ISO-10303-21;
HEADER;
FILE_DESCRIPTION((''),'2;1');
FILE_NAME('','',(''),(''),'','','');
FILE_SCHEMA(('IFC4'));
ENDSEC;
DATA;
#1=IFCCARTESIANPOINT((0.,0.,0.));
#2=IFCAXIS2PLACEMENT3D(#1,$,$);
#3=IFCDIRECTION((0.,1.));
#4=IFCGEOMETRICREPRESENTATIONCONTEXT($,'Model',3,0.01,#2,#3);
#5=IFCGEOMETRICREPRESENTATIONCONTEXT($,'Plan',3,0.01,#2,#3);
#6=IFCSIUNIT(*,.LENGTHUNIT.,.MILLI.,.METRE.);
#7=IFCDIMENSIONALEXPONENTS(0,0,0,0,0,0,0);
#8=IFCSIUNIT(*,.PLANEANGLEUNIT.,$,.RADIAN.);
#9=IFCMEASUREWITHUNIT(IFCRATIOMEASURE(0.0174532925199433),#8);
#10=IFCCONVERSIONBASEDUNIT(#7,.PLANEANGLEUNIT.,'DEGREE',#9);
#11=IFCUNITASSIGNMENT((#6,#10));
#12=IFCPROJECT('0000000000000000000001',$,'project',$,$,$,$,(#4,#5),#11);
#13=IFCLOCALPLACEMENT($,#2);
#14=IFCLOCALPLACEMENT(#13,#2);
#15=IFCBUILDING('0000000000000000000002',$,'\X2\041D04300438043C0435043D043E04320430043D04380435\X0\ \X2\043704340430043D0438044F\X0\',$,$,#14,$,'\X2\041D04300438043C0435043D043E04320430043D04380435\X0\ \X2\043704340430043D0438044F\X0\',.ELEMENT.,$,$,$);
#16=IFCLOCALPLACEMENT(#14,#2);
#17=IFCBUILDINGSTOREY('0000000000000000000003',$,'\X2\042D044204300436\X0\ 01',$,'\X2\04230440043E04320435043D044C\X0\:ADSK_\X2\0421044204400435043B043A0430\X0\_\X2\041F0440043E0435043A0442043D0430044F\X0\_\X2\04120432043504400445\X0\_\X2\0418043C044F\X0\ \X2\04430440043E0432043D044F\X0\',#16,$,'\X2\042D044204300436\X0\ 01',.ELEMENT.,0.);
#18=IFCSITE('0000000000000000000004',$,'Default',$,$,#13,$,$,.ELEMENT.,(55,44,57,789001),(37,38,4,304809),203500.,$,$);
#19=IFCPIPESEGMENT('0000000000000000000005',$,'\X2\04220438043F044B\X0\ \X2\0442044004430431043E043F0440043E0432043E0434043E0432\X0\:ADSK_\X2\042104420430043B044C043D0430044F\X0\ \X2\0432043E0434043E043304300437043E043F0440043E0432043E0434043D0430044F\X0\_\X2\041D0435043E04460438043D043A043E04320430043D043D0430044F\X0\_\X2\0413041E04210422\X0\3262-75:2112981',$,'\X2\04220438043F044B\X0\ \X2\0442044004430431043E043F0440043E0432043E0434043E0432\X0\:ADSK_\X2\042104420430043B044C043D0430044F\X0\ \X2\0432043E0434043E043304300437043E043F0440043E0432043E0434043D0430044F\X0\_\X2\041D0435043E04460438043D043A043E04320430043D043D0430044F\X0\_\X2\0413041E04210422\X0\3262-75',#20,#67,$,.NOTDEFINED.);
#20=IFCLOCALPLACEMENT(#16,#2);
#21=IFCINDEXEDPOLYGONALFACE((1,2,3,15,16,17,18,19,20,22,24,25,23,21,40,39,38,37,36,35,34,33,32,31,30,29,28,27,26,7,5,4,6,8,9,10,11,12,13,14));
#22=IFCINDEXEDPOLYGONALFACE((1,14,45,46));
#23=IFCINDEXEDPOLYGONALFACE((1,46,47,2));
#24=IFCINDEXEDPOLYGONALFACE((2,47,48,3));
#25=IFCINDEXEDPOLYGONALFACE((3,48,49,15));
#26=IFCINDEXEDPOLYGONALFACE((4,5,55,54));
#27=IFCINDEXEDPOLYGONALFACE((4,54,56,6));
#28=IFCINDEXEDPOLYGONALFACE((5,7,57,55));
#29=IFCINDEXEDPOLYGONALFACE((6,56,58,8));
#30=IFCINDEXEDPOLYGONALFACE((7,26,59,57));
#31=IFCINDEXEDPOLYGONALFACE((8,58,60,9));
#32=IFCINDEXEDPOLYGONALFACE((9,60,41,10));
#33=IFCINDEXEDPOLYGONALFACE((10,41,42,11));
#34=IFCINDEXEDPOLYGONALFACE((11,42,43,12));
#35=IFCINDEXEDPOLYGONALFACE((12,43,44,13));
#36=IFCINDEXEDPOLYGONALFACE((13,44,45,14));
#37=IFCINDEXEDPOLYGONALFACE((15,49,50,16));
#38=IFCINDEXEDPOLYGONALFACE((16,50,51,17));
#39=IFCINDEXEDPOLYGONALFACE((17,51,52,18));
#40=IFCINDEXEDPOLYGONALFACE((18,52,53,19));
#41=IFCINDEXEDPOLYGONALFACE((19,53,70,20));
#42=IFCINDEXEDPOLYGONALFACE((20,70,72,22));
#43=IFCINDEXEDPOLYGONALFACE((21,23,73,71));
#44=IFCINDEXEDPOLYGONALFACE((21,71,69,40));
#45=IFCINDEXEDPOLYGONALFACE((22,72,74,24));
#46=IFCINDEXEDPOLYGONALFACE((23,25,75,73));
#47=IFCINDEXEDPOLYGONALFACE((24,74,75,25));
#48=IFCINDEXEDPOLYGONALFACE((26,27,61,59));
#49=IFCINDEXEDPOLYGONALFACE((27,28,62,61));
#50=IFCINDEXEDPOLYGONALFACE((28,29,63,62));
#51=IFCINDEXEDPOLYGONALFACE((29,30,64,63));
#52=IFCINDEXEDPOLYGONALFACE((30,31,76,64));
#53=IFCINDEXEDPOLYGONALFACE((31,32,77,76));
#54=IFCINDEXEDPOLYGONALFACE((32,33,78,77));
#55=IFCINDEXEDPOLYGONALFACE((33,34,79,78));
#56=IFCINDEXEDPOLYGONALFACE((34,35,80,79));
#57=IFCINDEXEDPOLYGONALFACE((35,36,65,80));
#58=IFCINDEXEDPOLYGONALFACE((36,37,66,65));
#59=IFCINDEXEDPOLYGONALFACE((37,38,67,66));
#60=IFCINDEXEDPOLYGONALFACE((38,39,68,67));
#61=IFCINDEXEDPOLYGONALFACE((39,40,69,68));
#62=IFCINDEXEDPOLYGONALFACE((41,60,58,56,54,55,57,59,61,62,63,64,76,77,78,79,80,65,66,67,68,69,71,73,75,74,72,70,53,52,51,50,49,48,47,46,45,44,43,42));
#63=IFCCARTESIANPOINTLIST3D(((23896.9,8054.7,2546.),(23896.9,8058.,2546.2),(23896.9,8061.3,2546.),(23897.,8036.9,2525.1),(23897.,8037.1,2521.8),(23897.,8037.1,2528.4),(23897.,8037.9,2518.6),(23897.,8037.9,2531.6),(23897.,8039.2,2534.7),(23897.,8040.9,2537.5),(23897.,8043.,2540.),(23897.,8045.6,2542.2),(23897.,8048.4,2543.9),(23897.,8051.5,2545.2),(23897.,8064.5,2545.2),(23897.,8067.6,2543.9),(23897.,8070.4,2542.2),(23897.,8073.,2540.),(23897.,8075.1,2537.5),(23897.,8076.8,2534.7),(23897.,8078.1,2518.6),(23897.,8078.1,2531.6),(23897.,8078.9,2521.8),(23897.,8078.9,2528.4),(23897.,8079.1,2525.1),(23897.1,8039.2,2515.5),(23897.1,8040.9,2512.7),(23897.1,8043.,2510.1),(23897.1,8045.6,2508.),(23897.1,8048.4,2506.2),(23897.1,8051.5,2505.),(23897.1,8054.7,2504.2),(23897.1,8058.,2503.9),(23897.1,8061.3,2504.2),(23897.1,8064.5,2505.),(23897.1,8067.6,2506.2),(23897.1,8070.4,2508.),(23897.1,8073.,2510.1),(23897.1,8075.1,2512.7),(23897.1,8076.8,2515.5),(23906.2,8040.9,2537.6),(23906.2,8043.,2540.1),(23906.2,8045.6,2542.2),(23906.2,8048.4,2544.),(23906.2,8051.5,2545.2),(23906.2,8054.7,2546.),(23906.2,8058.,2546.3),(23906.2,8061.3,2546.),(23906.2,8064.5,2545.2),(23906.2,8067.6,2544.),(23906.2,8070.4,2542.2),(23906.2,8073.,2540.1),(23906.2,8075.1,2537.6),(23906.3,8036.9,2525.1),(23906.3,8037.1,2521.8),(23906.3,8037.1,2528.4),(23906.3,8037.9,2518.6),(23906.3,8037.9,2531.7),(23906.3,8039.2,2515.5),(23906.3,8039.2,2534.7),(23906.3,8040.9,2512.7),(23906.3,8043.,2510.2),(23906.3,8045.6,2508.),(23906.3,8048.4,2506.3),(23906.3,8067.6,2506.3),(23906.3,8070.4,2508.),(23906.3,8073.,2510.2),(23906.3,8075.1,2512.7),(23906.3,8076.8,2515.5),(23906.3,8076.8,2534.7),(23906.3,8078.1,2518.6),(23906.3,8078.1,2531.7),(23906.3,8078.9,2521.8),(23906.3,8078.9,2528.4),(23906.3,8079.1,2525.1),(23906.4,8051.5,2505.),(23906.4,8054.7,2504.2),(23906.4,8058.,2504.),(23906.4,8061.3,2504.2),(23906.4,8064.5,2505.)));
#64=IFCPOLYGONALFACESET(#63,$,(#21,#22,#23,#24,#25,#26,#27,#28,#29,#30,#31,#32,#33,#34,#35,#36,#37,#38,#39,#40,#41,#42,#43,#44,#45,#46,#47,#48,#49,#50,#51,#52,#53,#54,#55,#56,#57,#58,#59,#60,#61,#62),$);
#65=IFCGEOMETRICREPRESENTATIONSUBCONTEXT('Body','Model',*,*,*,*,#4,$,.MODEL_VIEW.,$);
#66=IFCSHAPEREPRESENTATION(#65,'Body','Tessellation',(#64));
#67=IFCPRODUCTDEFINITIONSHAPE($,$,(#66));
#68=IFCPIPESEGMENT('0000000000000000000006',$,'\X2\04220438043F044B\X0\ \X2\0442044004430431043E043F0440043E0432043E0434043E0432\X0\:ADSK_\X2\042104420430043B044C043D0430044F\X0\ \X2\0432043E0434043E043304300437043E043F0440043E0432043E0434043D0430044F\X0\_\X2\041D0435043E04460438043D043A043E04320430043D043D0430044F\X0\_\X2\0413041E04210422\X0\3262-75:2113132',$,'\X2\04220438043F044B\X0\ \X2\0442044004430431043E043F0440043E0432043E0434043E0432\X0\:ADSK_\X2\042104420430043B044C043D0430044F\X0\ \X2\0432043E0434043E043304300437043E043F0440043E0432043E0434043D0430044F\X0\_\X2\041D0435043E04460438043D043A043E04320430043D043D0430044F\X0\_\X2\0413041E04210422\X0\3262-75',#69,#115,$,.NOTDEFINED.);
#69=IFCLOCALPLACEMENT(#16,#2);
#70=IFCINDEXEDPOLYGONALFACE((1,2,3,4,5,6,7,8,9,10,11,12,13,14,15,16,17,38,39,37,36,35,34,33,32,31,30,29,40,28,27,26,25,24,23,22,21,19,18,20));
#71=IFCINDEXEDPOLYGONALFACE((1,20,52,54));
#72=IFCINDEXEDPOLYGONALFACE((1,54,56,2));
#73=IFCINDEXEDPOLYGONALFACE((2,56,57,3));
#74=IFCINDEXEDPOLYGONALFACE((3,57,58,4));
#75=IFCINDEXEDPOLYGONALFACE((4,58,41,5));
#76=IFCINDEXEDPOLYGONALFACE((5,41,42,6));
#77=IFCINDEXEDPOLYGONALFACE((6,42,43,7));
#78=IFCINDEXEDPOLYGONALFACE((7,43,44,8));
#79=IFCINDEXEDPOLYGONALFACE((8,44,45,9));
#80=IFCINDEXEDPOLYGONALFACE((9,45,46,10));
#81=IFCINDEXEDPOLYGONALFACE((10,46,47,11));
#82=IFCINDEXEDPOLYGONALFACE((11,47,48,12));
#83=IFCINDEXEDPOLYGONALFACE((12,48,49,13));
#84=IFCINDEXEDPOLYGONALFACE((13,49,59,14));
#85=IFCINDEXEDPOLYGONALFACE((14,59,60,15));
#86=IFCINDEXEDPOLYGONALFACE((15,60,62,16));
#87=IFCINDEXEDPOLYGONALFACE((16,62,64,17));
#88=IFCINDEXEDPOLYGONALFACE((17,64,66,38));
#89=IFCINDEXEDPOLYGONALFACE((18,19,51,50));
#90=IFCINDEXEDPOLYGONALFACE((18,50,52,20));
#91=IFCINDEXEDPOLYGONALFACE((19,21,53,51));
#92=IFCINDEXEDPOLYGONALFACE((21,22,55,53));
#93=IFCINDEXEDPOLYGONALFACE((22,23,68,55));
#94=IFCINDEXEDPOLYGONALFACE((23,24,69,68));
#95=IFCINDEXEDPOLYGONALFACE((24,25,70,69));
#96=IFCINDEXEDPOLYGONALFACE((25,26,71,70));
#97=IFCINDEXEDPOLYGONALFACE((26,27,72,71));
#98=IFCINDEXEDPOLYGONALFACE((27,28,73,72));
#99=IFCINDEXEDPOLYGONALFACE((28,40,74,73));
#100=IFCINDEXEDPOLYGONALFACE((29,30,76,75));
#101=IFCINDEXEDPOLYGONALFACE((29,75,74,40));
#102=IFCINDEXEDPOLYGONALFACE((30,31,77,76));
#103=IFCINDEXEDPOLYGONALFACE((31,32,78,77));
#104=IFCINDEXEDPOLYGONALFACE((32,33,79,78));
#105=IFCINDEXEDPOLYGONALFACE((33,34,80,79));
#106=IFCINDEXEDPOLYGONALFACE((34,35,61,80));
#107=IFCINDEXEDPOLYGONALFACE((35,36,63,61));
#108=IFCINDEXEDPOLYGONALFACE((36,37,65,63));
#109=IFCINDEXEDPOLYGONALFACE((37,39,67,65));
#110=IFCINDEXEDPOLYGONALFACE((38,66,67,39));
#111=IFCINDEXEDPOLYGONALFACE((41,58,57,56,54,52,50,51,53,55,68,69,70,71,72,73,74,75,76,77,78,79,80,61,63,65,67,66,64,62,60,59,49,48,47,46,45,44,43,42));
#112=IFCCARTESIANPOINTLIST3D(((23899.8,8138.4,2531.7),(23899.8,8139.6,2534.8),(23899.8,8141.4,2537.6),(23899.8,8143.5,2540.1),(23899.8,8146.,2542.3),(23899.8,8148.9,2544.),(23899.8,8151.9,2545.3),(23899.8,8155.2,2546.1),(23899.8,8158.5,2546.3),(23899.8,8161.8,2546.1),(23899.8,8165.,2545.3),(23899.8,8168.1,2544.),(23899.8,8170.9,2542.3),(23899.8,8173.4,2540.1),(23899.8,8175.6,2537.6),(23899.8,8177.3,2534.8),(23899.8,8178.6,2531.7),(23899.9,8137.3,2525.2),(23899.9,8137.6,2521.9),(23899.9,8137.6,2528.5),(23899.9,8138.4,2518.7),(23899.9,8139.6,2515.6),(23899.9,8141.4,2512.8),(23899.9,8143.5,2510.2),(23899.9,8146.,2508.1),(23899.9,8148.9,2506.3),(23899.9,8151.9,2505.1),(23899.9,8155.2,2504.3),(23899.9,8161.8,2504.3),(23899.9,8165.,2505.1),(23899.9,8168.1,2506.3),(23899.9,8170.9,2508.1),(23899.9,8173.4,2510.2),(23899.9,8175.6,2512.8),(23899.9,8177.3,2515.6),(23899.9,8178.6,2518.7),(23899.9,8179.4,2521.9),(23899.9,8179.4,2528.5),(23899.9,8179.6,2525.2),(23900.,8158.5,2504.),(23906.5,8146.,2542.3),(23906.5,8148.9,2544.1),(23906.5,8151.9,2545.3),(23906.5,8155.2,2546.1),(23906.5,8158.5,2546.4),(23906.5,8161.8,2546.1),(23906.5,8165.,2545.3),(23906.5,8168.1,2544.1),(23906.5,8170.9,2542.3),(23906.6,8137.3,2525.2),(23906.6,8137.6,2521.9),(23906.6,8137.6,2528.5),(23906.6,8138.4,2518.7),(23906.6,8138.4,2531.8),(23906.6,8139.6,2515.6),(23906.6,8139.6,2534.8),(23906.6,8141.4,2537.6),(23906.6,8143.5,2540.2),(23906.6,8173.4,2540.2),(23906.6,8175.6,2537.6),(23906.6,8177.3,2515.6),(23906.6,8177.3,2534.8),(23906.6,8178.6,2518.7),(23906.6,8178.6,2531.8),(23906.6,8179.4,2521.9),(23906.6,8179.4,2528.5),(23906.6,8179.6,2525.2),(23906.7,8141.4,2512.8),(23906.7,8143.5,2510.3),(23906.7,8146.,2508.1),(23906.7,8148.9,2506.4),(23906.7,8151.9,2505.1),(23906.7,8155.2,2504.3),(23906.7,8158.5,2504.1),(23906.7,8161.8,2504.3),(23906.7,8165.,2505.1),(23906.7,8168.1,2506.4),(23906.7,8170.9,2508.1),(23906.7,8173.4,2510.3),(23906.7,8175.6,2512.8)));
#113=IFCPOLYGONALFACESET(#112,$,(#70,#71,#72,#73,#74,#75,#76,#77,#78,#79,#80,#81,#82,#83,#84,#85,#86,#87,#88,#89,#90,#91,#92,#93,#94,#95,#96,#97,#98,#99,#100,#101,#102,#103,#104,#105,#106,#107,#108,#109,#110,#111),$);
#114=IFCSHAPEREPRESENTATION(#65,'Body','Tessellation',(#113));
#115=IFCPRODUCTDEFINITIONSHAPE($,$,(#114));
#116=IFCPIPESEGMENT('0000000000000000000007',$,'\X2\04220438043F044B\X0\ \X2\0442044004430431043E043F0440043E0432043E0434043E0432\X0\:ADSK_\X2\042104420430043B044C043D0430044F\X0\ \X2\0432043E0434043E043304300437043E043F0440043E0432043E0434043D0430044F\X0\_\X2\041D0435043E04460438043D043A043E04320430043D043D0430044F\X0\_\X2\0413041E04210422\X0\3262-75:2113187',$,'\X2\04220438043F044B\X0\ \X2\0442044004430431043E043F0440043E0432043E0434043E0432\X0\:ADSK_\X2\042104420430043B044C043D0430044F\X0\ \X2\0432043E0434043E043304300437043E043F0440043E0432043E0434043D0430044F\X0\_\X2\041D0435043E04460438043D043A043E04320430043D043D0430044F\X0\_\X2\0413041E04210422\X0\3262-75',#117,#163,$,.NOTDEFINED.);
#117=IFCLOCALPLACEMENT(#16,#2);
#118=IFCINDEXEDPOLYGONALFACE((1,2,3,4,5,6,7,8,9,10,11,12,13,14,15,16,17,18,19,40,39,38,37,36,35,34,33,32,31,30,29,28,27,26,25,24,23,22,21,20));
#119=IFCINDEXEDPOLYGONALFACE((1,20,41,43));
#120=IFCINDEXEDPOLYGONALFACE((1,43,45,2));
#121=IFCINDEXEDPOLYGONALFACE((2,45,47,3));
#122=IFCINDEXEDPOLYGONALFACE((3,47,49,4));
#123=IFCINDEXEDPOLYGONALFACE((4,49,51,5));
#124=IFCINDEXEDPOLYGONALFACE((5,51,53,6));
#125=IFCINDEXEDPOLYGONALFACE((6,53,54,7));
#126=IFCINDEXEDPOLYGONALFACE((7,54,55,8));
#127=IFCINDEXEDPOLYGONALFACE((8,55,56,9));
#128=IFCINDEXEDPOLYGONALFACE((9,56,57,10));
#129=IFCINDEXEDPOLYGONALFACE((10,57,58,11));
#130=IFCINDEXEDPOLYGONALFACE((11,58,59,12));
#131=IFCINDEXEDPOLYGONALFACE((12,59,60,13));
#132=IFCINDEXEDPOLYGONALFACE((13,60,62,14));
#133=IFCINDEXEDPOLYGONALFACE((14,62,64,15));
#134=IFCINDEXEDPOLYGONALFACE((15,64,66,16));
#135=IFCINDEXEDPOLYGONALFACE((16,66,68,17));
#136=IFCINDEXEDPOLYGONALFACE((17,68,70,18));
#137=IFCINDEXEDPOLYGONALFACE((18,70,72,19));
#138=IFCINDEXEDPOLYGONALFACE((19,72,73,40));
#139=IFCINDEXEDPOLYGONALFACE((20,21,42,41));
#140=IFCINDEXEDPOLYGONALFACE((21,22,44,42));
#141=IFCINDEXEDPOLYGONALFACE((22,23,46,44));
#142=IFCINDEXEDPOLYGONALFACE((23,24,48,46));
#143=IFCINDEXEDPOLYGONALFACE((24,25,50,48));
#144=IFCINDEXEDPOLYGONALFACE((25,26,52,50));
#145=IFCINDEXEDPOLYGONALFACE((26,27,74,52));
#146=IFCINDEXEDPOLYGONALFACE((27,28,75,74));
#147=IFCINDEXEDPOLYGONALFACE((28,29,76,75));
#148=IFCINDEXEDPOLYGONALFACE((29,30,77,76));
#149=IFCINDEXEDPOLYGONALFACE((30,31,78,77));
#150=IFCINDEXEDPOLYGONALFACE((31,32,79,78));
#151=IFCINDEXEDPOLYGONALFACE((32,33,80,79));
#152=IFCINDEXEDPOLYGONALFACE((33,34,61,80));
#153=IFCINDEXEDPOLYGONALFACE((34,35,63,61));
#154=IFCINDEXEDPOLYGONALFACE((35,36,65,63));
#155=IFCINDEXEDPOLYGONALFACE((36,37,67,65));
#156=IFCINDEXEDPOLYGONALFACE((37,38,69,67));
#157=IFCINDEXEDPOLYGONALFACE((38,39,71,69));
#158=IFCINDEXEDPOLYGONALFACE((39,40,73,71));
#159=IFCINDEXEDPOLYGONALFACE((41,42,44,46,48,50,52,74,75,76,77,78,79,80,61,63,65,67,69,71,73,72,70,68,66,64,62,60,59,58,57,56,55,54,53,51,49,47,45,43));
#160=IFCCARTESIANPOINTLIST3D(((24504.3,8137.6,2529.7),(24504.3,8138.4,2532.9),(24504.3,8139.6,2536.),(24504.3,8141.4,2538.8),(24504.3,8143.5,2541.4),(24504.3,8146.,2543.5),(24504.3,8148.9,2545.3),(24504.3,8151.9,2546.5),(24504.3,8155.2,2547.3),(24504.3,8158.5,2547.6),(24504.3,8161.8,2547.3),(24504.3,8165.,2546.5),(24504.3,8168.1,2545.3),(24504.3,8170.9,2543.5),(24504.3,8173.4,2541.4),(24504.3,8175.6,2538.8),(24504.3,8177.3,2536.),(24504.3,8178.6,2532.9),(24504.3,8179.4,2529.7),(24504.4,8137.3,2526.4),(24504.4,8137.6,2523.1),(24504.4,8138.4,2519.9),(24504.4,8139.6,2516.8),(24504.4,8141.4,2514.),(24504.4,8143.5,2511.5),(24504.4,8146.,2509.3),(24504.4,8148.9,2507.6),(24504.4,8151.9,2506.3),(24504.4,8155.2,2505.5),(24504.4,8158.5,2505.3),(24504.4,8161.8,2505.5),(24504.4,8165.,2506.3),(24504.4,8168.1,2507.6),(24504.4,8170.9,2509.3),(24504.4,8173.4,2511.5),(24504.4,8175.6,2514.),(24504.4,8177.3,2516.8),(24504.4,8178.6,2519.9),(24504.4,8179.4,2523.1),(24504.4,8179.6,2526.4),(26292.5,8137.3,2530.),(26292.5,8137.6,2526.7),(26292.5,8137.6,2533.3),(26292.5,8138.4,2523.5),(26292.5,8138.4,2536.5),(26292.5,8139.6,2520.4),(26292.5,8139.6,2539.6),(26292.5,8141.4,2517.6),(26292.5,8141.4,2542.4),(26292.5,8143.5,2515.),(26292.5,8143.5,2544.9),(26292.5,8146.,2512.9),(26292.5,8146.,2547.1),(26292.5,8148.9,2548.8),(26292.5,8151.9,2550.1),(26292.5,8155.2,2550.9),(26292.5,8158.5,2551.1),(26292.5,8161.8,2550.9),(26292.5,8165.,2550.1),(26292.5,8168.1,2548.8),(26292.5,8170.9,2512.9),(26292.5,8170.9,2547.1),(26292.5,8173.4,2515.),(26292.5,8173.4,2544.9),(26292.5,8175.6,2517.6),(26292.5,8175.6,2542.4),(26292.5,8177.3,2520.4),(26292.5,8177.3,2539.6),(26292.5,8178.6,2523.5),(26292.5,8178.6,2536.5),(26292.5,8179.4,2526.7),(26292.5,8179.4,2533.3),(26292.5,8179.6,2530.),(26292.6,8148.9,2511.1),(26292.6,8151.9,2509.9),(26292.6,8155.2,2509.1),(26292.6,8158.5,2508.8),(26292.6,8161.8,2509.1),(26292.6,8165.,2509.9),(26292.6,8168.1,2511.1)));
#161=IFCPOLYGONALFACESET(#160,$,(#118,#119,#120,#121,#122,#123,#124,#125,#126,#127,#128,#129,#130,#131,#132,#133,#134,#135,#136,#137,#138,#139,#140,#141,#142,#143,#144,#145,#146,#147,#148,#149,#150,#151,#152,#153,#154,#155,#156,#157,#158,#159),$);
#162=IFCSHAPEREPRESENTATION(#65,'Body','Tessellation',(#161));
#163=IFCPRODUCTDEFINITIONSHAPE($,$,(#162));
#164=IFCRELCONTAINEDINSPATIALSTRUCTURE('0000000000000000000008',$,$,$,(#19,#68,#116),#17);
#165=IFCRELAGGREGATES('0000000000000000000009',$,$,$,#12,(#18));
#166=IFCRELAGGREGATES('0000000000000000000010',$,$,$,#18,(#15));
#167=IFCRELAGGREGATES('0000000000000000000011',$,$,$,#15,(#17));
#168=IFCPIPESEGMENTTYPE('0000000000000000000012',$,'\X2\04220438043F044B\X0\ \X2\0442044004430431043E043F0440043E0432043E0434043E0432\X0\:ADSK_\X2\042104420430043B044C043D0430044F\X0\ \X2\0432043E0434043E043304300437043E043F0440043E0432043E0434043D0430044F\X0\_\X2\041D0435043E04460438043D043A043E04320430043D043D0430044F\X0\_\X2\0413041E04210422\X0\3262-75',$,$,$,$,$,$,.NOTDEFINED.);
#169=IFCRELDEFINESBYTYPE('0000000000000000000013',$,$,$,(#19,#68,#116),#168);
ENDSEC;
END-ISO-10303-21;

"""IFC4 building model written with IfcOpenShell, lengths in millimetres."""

from ifc_helpers import new_model, entity, si_unit, converted_unit, direction, frame, origin, place, context, subcontext, project, spatial, indexed_curve, outline, extrude, type_object, element, save


model = new_model("IFC4")

# Units and contexts
model_context = context("Model", 3, precision=0.01, world=origin(), true_north=direction((0.0, 1.0)))
plan_context = context("Plan", 3, precision=0.01, world=origin(), true_north=direction((0.0, 1.0)))
body_context = subcontext(model_context, "Body", "Model", "MODEL_VIEW")
ifc_project = project(units=[si_unit("LENGTHUNIT", "METRE", prefix="MILLI"), converted_unit("PLANEANGLEUNIT", "DEGREE", entity("IfcRatioMeasure", 0.0174532925199433), si_unit("PLANEANGLEUNIT", "RADIAN"), dimensions=[0, 0, 0, 0, 0, 0, 0])], contexts=[model_context, plan_context])

# Site, building, storey
site_placement = place(None, origin())
site = spatial("IfcSite", under=ifc_project, at=site_placement, Name="Default", CompositionType="ELEMENT", RefLatitude=(55, 44, 57, 789001), RefLongitude=(37, 38, 4, 304809), RefElevation=203500.0)
building_placement = place(site_placement, origin())
building = spatial("IfcBuilding", under=site, at=building_placement, Name="Наименование здания", LongName="Наименование здания", CompositionType="ELEMENT")
storey_placement = place(building_placement, origin())
storey = spatial("IfcBuildingStorey", under=building, at=storey_placement, Name="Этаж 01", ObjectType="Уровень:ADSK_Стрелка_Проектная_Вверх_Имя уровня", LongName="Этаж 01", CompositionType="ELEMENT", Elevation=0.0)

# Pipe segments
pipe_segment_type = type_object("IfcPipeSegmentType", Name="Типы трубопроводов:ADSK_Стальная водогазопроводная_Неоцинкованная_ГОСТ3262-75", PredefinedType="NOTDEFINED")
placement = place(storey_placement, origin())
element("IfcPipeSegment", 1, at=placement, inside=storey, type_object=pipe_segment_type, Name="Типы трубопроводов:ADSK_Стальная водогазопроводная_Неоцинкованная_ГОСТ3262-75:2112981", ObjectType="Типы трубопроводов:ADSK_Стальная водогазопроводная_Неоцинкованная_ГОСТ3262-75", PredefinedType="NOTDEFINED", context=body_context, shape_type="SweptSolid", body=[
    extrude(outline(indexed_curve([(21.1, 0.0), (20.9, 3.3), (20.1, 6.5), (18.8, 9.6), (17.1, 12.4), (15.0, 15.0), (12.4, 17.1), (9.6, 18.8), (6.5, 20.1), (3.3, 20.9), (0.0, 21.2), (-3.3, 20.9), (-6.5, 20.1), (-9.6, 18.8), (-12.4, 17.1), (-15.0, 15.0), (-17.1, 12.4), (-18.8, 9.6), (-20.1, 6.5), (-20.9, 3.3), (-21.1, 0.0), (-20.9, -3.3), (-20.1, -6.5), (-18.8, -9.6), (-17.1, -12.4), (-15.0, -15.0), (-12.4, -17.1), (-9.6, -18.8), (-6.5, -20.1), (-3.3, -20.9), (0.0, -21.2), (3.3, -20.9), (6.5, -20.1), (9.6, -18.8), (12.4, -17.1), (15.0, -15.0), (17.1, -12.4), (18.8, -9.6), (20.1, -6.5), (20.9, -3.3), (21.1, 0.0)], self_intersect=False)), frame((23897.0, 8058.0, 2525.1), z_axis=(0.999994, 0.0, 0.003404), x_axis=(0.0, 1.0, 0.0)), (0.0, 0.0, 1.0), 9.3),
])
element("IfcPipeSegment", 2, at=placement, inside=storey, type_object=pipe_segment_type, Name="Типы трубопроводов:ADSK_Стальная водогазопроводная_Неоцинкованная_ГОСТ3262-75:2113132", ObjectType="Типы трубопроводов:ADSK_Стальная водогазопроводная_Неоцинкованная_ГОСТ3262-75", PredefinedType="NOTDEFINED", context=body_context, shape_type="SweptSolid", body=[
    extrude(outline(indexed_curve([(21.2, 0.0), (20.9, 3.3), (20.1, 6.5), (18.8, 9.6), (17.1, 12.4), (15.0, 15.0), (12.4, 17.1), (9.6, 18.8), (6.5, 20.1), (3.3, 20.9), (0.0, 21.1), (-3.3, 20.9), (-6.5, 20.1), (-9.6, 18.8), (-12.4, 17.1), (-15.0, 15.0), (-17.1, 12.4), (-18.8, 9.6), (-20.1, 6.5), (-20.9, 3.3), (-21.2, 0.0), (-20.9, -3.3), (-20.1, -6.5), (-18.8, -9.6), (-17.1, -12.4), (-15.0, -15.0), (-12.4, -17.1), (-9.6, -18.8), (-6.5, -20.1), (-3.3, -20.9), (0.0, -21.1), (3.3, -20.9), (6.5, -20.1), (9.6, -18.8), (12.4, -17.1), (15.0, -15.0), (17.1, -12.4), (18.8, -9.6), (20.1, -6.5), (20.9, -3.3), (21.2, 0.0)], self_intersect=False)), frame((23899.9, 8158.5, 2525.2), z_axis=(0.999993, 0.000002, 0.003813), x_axis=(-0.000002, 1.0, 0.0)), (0.0, 0.0, 1.0), 6.7),
])
element("IfcPipeSegment", 3, at=placement, inside=storey, type_object=pipe_segment_type, Name="Типы трубопроводов:ADSK_Стальная водогазопроводная_Неоцинкованная_ГОСТ3262-75:2113187", ObjectType="Типы трубопроводов:ADSK_Стальная водогазопроводная_Неоцинкованная_ГОСТ3262-75", PredefinedType="NOTDEFINED", context=body_context, shape_type="SweptSolid", body=[
    extrude(outline(indexed_curve([(21.1, 0.0), (20.9, 3.3), (20.1, 6.5), (18.8, 9.6), (17.1, 12.4), (15.0, 15.0), (12.4, 17.1), (9.6, 18.8), (6.5, 20.1), (3.3, 20.9), (0.0, 21.1), (-3.3, 20.9), (-6.5, 20.1), (-9.6, 18.8), (-12.4, 17.1), (-15.0, 15.0), (-17.1, 12.4), (-18.8, 9.6), (-20.1, 6.5), (-20.9, 3.3), (-21.1, 0.0), (-20.9, -3.3), (-20.1, -6.5), (-18.8, -9.6), (-17.1, -12.4), (-15.0, -15.0), (-12.4, -17.1), (-9.6, -18.8), (-6.5, -20.1), (-3.3, -20.9), (0.0, -21.1), (3.3, -20.9), (6.5, -20.1), (9.6, -18.8), (12.4, -17.1), (15.0, -15.0), (17.1, -12.4), (18.8, -9.6), (20.1, -6.5), (20.9, -3.3), (21.1, 0.0)], self_intersect=False)), frame((24504.3, 8158.5, 2526.4), z_axis=(0.999998, 0.0, 0.002), x_axis=(0.0, 1.0, 0.0)), (0.0, 0.0, 1.0), 1788.2),
])

save(model, "model.ifc")
